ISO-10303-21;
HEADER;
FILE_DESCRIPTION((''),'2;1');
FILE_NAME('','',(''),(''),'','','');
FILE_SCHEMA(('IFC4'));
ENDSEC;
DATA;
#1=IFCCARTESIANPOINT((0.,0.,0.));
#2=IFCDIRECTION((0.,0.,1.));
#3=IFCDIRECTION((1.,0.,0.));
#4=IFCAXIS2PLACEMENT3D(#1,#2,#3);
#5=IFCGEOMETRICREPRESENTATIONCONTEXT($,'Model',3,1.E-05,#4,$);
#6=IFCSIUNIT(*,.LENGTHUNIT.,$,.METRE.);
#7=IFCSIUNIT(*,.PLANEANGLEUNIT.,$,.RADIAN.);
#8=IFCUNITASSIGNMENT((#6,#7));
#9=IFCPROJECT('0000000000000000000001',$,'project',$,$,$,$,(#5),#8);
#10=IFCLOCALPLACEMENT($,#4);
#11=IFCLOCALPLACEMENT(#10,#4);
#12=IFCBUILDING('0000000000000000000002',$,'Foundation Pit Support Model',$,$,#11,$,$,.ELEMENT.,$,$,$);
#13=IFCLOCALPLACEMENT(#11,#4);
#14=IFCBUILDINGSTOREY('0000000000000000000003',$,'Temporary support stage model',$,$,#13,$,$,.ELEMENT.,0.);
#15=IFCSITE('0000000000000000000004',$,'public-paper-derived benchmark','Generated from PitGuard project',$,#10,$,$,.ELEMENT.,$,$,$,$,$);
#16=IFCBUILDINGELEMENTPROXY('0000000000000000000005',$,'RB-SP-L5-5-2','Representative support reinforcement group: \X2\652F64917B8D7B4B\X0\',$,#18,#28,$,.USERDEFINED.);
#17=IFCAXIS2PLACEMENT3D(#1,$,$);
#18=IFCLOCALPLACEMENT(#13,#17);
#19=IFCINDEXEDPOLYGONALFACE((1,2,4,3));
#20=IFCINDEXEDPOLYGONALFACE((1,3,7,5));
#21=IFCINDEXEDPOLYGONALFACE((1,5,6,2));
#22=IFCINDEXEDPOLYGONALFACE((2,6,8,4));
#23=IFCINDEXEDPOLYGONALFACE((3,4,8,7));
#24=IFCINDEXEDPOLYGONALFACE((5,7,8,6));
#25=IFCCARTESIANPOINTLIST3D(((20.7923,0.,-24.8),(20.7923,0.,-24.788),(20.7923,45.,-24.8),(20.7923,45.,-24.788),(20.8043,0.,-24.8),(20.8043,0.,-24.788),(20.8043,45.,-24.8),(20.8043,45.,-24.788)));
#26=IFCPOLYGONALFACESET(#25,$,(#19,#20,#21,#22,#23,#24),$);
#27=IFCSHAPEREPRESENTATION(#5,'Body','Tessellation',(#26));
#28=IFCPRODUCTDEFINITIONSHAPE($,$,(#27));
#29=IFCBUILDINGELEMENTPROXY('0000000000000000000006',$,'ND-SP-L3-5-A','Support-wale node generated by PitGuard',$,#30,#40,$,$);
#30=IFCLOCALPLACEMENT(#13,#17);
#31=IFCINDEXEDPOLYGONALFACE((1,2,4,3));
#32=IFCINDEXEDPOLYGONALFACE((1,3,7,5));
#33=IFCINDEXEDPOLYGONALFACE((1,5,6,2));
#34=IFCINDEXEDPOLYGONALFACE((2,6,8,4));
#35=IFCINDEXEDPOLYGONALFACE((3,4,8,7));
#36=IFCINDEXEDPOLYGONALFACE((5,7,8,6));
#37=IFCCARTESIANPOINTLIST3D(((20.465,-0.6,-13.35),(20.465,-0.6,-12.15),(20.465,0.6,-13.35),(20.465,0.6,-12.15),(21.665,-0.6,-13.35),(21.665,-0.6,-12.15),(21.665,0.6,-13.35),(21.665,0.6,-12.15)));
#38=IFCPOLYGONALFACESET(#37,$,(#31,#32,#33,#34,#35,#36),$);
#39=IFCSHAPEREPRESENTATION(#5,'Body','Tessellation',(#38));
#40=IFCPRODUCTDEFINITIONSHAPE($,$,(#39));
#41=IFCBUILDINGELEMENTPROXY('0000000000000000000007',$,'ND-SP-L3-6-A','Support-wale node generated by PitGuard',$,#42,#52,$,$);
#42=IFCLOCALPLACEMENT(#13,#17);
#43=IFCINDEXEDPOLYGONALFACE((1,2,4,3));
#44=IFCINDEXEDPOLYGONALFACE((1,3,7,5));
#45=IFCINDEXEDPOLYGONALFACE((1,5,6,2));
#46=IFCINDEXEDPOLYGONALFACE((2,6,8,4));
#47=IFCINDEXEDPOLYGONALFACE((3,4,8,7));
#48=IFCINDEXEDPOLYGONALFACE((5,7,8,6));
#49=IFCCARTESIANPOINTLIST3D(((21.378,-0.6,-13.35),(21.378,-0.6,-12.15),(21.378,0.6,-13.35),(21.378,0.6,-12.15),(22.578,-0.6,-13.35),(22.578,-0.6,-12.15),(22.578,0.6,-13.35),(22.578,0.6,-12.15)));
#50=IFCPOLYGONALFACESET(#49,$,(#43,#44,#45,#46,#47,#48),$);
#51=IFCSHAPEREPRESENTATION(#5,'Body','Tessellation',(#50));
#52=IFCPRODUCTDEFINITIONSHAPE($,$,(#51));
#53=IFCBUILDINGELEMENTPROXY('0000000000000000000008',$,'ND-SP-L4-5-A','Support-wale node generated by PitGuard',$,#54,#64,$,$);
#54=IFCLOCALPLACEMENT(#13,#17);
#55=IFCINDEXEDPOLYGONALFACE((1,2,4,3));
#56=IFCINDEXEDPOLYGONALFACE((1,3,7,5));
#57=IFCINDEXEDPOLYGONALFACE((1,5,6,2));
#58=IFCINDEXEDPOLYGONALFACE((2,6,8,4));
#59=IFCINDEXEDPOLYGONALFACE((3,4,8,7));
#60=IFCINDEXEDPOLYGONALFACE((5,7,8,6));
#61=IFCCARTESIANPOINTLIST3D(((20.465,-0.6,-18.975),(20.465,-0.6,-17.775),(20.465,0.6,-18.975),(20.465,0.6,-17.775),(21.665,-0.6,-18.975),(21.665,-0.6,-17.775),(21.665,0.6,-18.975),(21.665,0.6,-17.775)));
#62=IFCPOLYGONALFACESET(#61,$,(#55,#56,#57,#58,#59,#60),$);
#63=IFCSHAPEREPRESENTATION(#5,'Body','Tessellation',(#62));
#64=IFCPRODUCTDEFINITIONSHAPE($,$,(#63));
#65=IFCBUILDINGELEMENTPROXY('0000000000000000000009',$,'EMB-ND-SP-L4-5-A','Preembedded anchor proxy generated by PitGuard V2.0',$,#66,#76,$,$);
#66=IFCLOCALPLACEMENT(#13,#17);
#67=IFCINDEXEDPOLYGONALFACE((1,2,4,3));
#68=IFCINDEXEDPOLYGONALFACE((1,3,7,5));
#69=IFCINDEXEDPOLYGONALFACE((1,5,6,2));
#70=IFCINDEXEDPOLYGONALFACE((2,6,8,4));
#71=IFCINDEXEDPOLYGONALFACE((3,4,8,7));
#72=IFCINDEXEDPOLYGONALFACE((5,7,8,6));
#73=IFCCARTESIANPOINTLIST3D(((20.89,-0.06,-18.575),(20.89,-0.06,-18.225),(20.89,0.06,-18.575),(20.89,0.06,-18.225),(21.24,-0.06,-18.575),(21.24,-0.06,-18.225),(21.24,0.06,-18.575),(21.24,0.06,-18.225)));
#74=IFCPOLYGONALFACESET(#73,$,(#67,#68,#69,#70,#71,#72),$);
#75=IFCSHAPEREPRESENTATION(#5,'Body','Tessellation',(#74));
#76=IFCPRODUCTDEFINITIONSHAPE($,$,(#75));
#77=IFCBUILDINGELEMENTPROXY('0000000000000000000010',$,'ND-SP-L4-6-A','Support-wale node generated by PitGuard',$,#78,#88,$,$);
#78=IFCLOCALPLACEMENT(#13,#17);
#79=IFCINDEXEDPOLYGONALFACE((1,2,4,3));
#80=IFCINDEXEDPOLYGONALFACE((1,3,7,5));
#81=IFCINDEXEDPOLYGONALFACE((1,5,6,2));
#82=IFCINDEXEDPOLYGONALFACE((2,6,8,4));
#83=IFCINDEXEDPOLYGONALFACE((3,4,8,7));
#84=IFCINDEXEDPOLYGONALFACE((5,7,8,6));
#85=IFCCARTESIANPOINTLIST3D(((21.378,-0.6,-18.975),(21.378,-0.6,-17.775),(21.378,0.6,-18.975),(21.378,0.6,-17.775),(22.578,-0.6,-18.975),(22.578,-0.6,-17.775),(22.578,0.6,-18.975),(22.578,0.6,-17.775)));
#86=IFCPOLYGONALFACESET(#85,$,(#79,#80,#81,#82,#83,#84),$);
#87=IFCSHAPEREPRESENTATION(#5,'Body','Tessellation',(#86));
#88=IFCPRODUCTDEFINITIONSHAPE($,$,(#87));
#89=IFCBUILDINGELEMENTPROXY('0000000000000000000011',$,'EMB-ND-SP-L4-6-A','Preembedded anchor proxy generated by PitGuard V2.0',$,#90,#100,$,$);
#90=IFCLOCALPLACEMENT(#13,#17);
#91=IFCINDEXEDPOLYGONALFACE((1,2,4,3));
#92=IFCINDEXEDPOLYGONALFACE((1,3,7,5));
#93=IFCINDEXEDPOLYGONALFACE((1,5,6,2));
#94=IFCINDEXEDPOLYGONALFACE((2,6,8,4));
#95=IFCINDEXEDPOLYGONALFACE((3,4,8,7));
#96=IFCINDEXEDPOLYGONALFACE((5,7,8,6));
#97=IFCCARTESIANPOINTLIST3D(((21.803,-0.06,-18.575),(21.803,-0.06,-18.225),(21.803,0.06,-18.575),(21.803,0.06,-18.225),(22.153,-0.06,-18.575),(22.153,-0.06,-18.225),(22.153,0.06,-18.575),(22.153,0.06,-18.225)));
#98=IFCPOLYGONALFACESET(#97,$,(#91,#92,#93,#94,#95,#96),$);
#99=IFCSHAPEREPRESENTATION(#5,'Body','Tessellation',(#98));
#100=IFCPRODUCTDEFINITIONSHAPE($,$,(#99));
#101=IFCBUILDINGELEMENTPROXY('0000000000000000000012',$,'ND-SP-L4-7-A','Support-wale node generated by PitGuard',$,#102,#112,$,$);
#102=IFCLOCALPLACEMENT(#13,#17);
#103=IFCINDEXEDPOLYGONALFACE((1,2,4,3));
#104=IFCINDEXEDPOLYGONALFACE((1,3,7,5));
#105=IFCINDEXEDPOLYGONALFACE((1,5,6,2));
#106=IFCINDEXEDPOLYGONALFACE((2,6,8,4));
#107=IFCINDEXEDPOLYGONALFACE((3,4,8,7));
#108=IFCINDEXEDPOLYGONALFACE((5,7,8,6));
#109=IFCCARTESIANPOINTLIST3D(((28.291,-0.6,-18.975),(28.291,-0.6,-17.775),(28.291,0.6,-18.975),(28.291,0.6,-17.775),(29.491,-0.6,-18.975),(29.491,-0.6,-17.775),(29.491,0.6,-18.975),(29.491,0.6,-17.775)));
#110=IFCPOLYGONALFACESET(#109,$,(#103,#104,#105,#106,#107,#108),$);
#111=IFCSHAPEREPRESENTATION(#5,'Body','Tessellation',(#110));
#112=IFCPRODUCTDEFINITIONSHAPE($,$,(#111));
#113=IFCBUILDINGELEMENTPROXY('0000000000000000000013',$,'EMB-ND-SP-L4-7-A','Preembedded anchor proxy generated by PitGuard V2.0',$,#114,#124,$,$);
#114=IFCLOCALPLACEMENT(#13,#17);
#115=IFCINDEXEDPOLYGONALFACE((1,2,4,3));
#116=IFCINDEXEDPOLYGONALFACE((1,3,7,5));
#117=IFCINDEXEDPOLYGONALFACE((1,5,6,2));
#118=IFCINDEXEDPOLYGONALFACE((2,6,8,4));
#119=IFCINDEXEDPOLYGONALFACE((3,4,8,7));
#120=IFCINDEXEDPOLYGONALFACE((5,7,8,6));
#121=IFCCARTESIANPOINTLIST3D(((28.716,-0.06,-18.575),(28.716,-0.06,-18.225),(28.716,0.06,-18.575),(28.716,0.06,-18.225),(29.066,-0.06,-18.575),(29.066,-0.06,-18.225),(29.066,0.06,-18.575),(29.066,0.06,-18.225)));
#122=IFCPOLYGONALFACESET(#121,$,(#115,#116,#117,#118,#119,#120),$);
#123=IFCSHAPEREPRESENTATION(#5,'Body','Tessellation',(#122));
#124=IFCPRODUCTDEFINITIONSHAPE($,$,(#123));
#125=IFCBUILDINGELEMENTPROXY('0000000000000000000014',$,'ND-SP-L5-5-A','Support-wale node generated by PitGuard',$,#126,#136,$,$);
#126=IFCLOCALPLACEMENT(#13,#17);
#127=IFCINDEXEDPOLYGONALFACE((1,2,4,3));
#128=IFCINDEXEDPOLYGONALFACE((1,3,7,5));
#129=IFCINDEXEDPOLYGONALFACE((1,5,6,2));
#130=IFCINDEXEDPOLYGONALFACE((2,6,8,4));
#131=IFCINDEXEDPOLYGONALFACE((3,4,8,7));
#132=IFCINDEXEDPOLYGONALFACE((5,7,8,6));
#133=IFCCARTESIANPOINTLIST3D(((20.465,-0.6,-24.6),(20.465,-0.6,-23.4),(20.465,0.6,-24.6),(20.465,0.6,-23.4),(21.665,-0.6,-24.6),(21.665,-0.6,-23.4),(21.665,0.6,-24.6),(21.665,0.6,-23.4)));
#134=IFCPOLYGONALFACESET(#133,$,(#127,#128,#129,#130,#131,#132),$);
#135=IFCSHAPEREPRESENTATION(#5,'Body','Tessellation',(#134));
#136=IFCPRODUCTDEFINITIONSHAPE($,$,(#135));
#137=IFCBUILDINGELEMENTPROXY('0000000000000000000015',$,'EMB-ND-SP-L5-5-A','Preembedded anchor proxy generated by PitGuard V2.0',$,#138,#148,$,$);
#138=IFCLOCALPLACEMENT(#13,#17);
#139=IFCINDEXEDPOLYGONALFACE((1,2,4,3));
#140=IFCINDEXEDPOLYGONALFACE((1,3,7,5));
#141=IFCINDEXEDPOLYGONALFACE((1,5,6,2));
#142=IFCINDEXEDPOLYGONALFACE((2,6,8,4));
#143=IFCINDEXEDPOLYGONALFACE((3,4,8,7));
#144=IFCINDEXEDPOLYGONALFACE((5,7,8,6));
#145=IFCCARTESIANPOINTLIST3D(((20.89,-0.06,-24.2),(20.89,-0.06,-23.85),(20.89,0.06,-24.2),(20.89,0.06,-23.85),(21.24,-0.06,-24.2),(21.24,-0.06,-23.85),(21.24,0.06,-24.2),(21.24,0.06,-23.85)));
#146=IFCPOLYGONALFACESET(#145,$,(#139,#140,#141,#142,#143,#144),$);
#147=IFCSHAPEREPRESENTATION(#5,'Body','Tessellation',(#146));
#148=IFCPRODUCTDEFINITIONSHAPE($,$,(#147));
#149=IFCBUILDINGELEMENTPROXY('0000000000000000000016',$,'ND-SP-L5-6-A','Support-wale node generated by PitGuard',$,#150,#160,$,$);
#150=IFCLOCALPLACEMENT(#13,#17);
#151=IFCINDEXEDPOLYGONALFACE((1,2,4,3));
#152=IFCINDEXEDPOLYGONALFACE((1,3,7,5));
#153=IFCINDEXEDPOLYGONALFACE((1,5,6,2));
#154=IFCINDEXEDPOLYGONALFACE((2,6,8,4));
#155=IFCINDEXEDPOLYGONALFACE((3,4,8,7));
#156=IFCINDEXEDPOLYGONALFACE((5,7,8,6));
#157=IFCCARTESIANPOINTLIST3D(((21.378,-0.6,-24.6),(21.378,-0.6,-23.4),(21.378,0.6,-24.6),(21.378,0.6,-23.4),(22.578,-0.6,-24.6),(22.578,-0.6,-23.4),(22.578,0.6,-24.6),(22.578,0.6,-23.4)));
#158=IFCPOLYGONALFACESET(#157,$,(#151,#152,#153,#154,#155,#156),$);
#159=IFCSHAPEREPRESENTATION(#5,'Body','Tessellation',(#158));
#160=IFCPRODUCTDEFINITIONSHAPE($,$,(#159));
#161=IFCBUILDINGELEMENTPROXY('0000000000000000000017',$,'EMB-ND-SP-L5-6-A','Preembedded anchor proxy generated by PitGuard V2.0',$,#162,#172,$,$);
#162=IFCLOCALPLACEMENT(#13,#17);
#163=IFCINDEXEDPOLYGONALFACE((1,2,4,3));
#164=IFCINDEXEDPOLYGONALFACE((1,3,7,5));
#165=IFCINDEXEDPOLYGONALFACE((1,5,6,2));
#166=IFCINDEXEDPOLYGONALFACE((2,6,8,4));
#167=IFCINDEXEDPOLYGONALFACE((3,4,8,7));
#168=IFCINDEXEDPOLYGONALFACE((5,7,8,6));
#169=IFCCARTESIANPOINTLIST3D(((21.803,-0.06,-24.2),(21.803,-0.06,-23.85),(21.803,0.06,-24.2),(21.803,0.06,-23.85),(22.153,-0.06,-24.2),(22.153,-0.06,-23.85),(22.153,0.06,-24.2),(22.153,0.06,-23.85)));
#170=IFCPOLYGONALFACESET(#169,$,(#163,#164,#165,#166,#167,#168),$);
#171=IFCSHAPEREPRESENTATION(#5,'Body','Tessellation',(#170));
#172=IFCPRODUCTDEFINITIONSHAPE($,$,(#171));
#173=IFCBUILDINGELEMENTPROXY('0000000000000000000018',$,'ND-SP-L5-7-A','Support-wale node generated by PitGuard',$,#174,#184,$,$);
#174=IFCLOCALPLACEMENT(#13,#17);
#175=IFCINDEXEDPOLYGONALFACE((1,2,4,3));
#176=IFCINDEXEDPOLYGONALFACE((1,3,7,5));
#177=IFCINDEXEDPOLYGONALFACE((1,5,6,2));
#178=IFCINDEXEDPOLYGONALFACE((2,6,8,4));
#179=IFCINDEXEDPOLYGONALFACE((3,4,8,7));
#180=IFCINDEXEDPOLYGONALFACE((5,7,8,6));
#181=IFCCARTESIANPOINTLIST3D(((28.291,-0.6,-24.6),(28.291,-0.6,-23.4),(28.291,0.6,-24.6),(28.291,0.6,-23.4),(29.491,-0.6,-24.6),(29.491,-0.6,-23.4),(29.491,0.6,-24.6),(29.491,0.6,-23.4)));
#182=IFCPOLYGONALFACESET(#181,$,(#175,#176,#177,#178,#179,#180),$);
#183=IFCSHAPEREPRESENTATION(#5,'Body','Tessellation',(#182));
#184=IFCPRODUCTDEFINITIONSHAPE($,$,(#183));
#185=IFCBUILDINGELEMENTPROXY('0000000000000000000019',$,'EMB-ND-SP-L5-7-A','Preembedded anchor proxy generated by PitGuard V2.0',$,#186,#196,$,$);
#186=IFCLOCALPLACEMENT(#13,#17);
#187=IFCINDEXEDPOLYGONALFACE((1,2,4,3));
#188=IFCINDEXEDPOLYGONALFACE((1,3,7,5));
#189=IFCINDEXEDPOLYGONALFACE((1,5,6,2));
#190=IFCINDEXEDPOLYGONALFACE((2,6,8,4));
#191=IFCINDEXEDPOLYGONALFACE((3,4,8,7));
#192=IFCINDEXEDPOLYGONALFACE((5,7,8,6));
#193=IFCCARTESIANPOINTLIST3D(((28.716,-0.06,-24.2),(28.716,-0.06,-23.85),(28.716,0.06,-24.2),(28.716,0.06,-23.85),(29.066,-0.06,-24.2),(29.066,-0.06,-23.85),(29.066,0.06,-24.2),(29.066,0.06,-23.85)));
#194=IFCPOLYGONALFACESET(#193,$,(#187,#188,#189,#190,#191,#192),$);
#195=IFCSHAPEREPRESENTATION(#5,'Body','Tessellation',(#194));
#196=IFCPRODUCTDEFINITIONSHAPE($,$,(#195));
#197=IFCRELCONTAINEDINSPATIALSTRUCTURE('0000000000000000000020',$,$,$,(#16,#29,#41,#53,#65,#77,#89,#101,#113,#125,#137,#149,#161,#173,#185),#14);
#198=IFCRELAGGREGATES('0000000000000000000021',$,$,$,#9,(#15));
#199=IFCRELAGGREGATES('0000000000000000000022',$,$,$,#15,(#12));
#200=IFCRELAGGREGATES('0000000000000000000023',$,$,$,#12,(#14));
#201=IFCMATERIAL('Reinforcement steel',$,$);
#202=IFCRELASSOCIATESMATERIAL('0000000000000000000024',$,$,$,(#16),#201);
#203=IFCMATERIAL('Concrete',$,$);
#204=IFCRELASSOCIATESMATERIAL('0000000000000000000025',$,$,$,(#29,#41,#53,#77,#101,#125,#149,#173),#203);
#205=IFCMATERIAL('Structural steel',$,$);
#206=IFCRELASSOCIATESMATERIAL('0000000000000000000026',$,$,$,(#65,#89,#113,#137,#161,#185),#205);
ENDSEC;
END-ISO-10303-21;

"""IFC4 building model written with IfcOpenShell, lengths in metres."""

from ifc_helpers import new_model, si_unit, frame, origin_with_axes, origin_2d, place, context, project, spatial, rectangle, extrude, material, element, save


model = new_model("IFC4")

# Units and contexts
model_context = context("Model", 3, precision=1e-05, world=origin_with_axes())
ifc_project = project(units=[si_unit("LENGTHUNIT", "METRE"), si_unit("PLANEANGLEUNIT", "RADIAN")], contexts=[model_context])

# Site, building, storey
site_placement = place(None, origin_with_axes())
site = spatial("IfcSite", under=ifc_project, at=site_placement, Name="public-paper-derived benchmark", Description="Generated from PitGuard project", CompositionType="ELEMENT")
building_placement = place(site_placement, origin_with_axes())
building = spatial("IfcBuilding", under=site, at=building_placement, Name="Foundation Pit Support Model", CompositionType="ELEMENT")
storey_placement = place(building_placement, origin_with_axes())
storey = spatial("IfcBuildingStorey", under=building, at=storey_placement, Name="Temporary support stage model", CompositionType="ELEMENT", Elevation=0.0)

# Shared definitions
ifc_material_1 = material(Name="Structural steel")

# Shared definitions
ifc_material_2 = material(Name="Concrete")

# Building element proxies
ifc_material_3 = material(Name="Reinforcement steel")
proxy_1_placement = place(storey_placement, frame((20.7983, 22.5, -24.8), z_axis=(0.0, 0.0, 1.0), x_axis=(0.0, 1.0, 0.0)))
element("IfcBuildingElementProxy", 1, at=proxy_1_placement, inside=storey, material=ifc_material_3, Name="RB-SP-L5-5-2", Description="Representative support reinforcement group: 支撑箍筋", PredefinedType="USERDEFINED", context=model_context, shape_type="SweptSolid", body=[
    extrude(rectangle(XDim=45.0, YDim=0.012, at=origin_2d()), origin_with_axes(), (0.0, 0.0, 1.0), 0.012),
])
for number, where, z_axis, x_axis, name in (
    (2, (21.065, 0.0, -13.35), (0.0, 0.0, 1.0), (1.0, 0.0, 0.0), "ND-SP-L3-5-A"),
    (3, (21.978, 0.0, -13.35), (0.0, 0.0, 1.0), (1.0, 0.0, 0.0), "ND-SP-L3-6-A"),
    (4, (21.065, 0.0, -18.975), (0.0, 0.0, 1.0), (1.0, 0.0, 0.0), "ND-SP-L4-5-A"),
):
    element("IfcBuildingElementProxy", number, at=place(storey_placement, frame(where, z_axis=z_axis, x_axis=x_axis)), inside=storey, material=ifc_material_2, Name=name, Description="Support-wale node generated by PitGuard", context=model_context, shape_type="SweptSolid", body=[
        extrude(rectangle(XDim=1.2, YDim=1.2, at=origin_2d()), origin_with_axes(), (0.0, 0.0, 1.0), 1.2),
    ])
proxy_2_placement = place(storey_placement, frame((21.065, 0.0, -18.575), z_axis=(0.0, 0.0, 1.0), x_axis=(1.0, 0.0, 0.0)))
element("IfcBuildingElementProxy", 5, at=proxy_2_placement, inside=storey, material=ifc_material_1, Name="EMB-ND-SP-L4-5-A", Description="Preembedded anchor proxy generated by PitGuard V2.0", context=model_context, shape_type="SweptSolid", body=[
    extrude(rectangle(XDim=0.35, YDim=0.12, at=origin_2d()), origin_with_axes(), (0.0, 0.0, 1.0), 0.35),
])
proxy_3_placement = place(storey_placement, frame((21.978, 0.0, -18.975), z_axis=(0.0, 0.0, 1.0), x_axis=(1.0, 0.0, 0.0)))
element("IfcBuildingElementProxy", 6, at=proxy_3_placement, inside=storey, material=ifc_material_2, Name="ND-SP-L4-6-A", Description="Support-wale node generated by PitGuard", context=model_context, shape_type="SweptSolid", body=[
    extrude(rectangle(XDim=1.2, YDim=1.2, at=origin_2d()), origin_with_axes(), (0.0, 0.0, 1.0), 1.2),
])
proxy_4_placement = place(storey_placement, frame((21.978, 0.0, -18.575), z_axis=(0.0, 0.0, 1.0), x_axis=(1.0, 0.0, 0.0)))
element("IfcBuildingElementProxy", 7, at=proxy_4_placement, inside=storey, material=ifc_material_1, Name="EMB-ND-SP-L4-6-A", Description="Preembedded anchor proxy generated by PitGuard V2.0", context=model_context, shape_type="SweptSolid", body=[
    extrude(rectangle(XDim=0.35, YDim=0.12, at=origin_2d()), origin_with_axes(), (0.0, 0.0, 1.0), 0.35),
])
proxy_5_placement = place(storey_placement, frame((28.891, 0.0, -18.975), z_axis=(0.0, 0.0, 1.0), x_axis=(1.0, 0.0, 0.0)))
element("IfcBuildingElementProxy", 8, at=proxy_5_placement, inside=storey, material=ifc_material_2, Name="ND-SP-L4-7-A", Description="Support-wale node generated by PitGuard", context=model_context, shape_type="SweptSolid", body=[
    extrude(rectangle(XDim=1.2, YDim=1.2, at=origin_2d()), origin_with_axes(), (0.0, 0.0, 1.0), 1.2),
])
proxy_6_placement = place(storey_placement, frame((28.891, 0.0, -18.575), z_axis=(0.0, 0.0, 1.0), x_axis=(1.0, 0.0, 0.0)))
element("IfcBuildingElementProxy", 9, at=proxy_6_placement, inside=storey, material=ifc_material_1, Name="EMB-ND-SP-L4-7-A", Description="Preembedded anchor proxy generated by PitGuard V2.0", context=model_context, shape_type="SweptSolid", body=[
    extrude(rectangle(XDim=0.35, YDim=0.12, at=origin_2d()), origin_with_axes(), (0.0, 0.0, 1.0), 0.35),
])
proxy_7_placement = place(storey_placement, frame((21.065, 0.0, -24.6), z_axis=(0.0, 0.0, 1.0), x_axis=(1.0, 0.0, 0.0)))
element("IfcBuildingElementProxy", 10, at=proxy_7_placement, inside=storey, material=ifc_material_2, Name="ND-SP-L5-5-A", Description="Support-wale node generated by PitGuard", context=model_context, shape_type="SweptSolid", body=[
    extrude(rectangle(XDim=1.2, YDim=1.2, at=origin_2d()), origin_with_axes(), (0.0, 0.0, 1.0), 1.2),
])
proxy_8_placement = place(storey_placement, frame((21.065, 0.0, -24.2), z_axis=(0.0, 0.0, 1.0), x_axis=(1.0, 0.0, 0.0)))
element("IfcBuildingElementProxy", 11, at=proxy_8_placement, inside=storey, material=ifc_material_1, Name="EMB-ND-SP-L5-5-A", Description="Preembedded anchor proxy generated by PitGuard V2.0", context=model_context, shape_type="SweptSolid", body=[
    extrude(rectangle(XDim=0.35, YDim=0.12, at=origin_2d()), origin_with_axes(), (0.0, 0.0, 1.0), 0.35),
])
proxy_9_placement = place(storey_placement, frame((21.978, 0.0, -24.6), z_axis=(0.0, 0.0, 1.0), x_axis=(1.0, 0.0, 0.0)))
element("IfcBuildingElementProxy", 12, at=proxy_9_placement, inside=storey, material=ifc_material_2, Name="ND-SP-L5-6-A", Description="Support-wale node generated by PitGuard", context=model_context, shape_type="SweptSolid", body=[
    extrude(rectangle(XDim=1.2, YDim=1.2, at=origin_2d()), origin_with_axes(), (0.0, 0.0, 1.0), 1.2),
])
proxy_10_placement = place(storey_placement, frame((21.978, 0.0, -24.2), z_axis=(0.0, 0.0, 1.0), x_axis=(1.0, 0.0, 0.0)))
element("IfcBuildingElementProxy", 13, at=proxy_10_placement, inside=storey, material=ifc_material_1, Name="EMB-ND-SP-L5-6-A", Description="Preembedded anchor proxy generated by PitGuard V2.0", context=model_context, shape_type="SweptSolid", body=[
    extrude(rectangle(XDim=0.35, YDim=0.12, at=origin_2d()), origin_with_axes(), (0.0, 0.0, 1.0), 0.35),
])
proxy_11_placement = place(storey_placement, frame((28.891, 0.0, -24.6), z_axis=(0.0, 0.0, 1.0), x_axis=(1.0, 0.0, 0.0)))
element("IfcBuildingElementProxy", 14, at=proxy_11_placement, inside=storey, material=ifc_material_2, Name="ND-SP-L5-7-A", Description="Support-wale node generated by PitGuard", context=model_context, shape_type="SweptSolid", body=[
    extrude(rectangle(XDim=1.2, YDim=1.2, at=origin_2d()), origin_with_axes(), (0.0, 0.0, 1.0), 1.2),
])
proxy_12_placement = place(storey_placement, frame((28.891, 0.0, -24.2), z_axis=(0.0, 0.0, 1.0), x_axis=(1.0, 0.0, 0.0)))
element("IfcBuildingElementProxy", 15, at=proxy_12_placement, inside=storey, material=ifc_material_1, Name="EMB-ND-SP-L5-7-A", Description="Preembedded anchor proxy generated by PitGuard V2.0", context=model_context, shape_type="SweptSolid", body=[
    extrude(rectangle(XDim=0.35, YDim=0.12, at=origin_2d()), origin_with_axes(), (0.0, 0.0, 1.0), 0.35),
])

save(model, "model.ifc")
